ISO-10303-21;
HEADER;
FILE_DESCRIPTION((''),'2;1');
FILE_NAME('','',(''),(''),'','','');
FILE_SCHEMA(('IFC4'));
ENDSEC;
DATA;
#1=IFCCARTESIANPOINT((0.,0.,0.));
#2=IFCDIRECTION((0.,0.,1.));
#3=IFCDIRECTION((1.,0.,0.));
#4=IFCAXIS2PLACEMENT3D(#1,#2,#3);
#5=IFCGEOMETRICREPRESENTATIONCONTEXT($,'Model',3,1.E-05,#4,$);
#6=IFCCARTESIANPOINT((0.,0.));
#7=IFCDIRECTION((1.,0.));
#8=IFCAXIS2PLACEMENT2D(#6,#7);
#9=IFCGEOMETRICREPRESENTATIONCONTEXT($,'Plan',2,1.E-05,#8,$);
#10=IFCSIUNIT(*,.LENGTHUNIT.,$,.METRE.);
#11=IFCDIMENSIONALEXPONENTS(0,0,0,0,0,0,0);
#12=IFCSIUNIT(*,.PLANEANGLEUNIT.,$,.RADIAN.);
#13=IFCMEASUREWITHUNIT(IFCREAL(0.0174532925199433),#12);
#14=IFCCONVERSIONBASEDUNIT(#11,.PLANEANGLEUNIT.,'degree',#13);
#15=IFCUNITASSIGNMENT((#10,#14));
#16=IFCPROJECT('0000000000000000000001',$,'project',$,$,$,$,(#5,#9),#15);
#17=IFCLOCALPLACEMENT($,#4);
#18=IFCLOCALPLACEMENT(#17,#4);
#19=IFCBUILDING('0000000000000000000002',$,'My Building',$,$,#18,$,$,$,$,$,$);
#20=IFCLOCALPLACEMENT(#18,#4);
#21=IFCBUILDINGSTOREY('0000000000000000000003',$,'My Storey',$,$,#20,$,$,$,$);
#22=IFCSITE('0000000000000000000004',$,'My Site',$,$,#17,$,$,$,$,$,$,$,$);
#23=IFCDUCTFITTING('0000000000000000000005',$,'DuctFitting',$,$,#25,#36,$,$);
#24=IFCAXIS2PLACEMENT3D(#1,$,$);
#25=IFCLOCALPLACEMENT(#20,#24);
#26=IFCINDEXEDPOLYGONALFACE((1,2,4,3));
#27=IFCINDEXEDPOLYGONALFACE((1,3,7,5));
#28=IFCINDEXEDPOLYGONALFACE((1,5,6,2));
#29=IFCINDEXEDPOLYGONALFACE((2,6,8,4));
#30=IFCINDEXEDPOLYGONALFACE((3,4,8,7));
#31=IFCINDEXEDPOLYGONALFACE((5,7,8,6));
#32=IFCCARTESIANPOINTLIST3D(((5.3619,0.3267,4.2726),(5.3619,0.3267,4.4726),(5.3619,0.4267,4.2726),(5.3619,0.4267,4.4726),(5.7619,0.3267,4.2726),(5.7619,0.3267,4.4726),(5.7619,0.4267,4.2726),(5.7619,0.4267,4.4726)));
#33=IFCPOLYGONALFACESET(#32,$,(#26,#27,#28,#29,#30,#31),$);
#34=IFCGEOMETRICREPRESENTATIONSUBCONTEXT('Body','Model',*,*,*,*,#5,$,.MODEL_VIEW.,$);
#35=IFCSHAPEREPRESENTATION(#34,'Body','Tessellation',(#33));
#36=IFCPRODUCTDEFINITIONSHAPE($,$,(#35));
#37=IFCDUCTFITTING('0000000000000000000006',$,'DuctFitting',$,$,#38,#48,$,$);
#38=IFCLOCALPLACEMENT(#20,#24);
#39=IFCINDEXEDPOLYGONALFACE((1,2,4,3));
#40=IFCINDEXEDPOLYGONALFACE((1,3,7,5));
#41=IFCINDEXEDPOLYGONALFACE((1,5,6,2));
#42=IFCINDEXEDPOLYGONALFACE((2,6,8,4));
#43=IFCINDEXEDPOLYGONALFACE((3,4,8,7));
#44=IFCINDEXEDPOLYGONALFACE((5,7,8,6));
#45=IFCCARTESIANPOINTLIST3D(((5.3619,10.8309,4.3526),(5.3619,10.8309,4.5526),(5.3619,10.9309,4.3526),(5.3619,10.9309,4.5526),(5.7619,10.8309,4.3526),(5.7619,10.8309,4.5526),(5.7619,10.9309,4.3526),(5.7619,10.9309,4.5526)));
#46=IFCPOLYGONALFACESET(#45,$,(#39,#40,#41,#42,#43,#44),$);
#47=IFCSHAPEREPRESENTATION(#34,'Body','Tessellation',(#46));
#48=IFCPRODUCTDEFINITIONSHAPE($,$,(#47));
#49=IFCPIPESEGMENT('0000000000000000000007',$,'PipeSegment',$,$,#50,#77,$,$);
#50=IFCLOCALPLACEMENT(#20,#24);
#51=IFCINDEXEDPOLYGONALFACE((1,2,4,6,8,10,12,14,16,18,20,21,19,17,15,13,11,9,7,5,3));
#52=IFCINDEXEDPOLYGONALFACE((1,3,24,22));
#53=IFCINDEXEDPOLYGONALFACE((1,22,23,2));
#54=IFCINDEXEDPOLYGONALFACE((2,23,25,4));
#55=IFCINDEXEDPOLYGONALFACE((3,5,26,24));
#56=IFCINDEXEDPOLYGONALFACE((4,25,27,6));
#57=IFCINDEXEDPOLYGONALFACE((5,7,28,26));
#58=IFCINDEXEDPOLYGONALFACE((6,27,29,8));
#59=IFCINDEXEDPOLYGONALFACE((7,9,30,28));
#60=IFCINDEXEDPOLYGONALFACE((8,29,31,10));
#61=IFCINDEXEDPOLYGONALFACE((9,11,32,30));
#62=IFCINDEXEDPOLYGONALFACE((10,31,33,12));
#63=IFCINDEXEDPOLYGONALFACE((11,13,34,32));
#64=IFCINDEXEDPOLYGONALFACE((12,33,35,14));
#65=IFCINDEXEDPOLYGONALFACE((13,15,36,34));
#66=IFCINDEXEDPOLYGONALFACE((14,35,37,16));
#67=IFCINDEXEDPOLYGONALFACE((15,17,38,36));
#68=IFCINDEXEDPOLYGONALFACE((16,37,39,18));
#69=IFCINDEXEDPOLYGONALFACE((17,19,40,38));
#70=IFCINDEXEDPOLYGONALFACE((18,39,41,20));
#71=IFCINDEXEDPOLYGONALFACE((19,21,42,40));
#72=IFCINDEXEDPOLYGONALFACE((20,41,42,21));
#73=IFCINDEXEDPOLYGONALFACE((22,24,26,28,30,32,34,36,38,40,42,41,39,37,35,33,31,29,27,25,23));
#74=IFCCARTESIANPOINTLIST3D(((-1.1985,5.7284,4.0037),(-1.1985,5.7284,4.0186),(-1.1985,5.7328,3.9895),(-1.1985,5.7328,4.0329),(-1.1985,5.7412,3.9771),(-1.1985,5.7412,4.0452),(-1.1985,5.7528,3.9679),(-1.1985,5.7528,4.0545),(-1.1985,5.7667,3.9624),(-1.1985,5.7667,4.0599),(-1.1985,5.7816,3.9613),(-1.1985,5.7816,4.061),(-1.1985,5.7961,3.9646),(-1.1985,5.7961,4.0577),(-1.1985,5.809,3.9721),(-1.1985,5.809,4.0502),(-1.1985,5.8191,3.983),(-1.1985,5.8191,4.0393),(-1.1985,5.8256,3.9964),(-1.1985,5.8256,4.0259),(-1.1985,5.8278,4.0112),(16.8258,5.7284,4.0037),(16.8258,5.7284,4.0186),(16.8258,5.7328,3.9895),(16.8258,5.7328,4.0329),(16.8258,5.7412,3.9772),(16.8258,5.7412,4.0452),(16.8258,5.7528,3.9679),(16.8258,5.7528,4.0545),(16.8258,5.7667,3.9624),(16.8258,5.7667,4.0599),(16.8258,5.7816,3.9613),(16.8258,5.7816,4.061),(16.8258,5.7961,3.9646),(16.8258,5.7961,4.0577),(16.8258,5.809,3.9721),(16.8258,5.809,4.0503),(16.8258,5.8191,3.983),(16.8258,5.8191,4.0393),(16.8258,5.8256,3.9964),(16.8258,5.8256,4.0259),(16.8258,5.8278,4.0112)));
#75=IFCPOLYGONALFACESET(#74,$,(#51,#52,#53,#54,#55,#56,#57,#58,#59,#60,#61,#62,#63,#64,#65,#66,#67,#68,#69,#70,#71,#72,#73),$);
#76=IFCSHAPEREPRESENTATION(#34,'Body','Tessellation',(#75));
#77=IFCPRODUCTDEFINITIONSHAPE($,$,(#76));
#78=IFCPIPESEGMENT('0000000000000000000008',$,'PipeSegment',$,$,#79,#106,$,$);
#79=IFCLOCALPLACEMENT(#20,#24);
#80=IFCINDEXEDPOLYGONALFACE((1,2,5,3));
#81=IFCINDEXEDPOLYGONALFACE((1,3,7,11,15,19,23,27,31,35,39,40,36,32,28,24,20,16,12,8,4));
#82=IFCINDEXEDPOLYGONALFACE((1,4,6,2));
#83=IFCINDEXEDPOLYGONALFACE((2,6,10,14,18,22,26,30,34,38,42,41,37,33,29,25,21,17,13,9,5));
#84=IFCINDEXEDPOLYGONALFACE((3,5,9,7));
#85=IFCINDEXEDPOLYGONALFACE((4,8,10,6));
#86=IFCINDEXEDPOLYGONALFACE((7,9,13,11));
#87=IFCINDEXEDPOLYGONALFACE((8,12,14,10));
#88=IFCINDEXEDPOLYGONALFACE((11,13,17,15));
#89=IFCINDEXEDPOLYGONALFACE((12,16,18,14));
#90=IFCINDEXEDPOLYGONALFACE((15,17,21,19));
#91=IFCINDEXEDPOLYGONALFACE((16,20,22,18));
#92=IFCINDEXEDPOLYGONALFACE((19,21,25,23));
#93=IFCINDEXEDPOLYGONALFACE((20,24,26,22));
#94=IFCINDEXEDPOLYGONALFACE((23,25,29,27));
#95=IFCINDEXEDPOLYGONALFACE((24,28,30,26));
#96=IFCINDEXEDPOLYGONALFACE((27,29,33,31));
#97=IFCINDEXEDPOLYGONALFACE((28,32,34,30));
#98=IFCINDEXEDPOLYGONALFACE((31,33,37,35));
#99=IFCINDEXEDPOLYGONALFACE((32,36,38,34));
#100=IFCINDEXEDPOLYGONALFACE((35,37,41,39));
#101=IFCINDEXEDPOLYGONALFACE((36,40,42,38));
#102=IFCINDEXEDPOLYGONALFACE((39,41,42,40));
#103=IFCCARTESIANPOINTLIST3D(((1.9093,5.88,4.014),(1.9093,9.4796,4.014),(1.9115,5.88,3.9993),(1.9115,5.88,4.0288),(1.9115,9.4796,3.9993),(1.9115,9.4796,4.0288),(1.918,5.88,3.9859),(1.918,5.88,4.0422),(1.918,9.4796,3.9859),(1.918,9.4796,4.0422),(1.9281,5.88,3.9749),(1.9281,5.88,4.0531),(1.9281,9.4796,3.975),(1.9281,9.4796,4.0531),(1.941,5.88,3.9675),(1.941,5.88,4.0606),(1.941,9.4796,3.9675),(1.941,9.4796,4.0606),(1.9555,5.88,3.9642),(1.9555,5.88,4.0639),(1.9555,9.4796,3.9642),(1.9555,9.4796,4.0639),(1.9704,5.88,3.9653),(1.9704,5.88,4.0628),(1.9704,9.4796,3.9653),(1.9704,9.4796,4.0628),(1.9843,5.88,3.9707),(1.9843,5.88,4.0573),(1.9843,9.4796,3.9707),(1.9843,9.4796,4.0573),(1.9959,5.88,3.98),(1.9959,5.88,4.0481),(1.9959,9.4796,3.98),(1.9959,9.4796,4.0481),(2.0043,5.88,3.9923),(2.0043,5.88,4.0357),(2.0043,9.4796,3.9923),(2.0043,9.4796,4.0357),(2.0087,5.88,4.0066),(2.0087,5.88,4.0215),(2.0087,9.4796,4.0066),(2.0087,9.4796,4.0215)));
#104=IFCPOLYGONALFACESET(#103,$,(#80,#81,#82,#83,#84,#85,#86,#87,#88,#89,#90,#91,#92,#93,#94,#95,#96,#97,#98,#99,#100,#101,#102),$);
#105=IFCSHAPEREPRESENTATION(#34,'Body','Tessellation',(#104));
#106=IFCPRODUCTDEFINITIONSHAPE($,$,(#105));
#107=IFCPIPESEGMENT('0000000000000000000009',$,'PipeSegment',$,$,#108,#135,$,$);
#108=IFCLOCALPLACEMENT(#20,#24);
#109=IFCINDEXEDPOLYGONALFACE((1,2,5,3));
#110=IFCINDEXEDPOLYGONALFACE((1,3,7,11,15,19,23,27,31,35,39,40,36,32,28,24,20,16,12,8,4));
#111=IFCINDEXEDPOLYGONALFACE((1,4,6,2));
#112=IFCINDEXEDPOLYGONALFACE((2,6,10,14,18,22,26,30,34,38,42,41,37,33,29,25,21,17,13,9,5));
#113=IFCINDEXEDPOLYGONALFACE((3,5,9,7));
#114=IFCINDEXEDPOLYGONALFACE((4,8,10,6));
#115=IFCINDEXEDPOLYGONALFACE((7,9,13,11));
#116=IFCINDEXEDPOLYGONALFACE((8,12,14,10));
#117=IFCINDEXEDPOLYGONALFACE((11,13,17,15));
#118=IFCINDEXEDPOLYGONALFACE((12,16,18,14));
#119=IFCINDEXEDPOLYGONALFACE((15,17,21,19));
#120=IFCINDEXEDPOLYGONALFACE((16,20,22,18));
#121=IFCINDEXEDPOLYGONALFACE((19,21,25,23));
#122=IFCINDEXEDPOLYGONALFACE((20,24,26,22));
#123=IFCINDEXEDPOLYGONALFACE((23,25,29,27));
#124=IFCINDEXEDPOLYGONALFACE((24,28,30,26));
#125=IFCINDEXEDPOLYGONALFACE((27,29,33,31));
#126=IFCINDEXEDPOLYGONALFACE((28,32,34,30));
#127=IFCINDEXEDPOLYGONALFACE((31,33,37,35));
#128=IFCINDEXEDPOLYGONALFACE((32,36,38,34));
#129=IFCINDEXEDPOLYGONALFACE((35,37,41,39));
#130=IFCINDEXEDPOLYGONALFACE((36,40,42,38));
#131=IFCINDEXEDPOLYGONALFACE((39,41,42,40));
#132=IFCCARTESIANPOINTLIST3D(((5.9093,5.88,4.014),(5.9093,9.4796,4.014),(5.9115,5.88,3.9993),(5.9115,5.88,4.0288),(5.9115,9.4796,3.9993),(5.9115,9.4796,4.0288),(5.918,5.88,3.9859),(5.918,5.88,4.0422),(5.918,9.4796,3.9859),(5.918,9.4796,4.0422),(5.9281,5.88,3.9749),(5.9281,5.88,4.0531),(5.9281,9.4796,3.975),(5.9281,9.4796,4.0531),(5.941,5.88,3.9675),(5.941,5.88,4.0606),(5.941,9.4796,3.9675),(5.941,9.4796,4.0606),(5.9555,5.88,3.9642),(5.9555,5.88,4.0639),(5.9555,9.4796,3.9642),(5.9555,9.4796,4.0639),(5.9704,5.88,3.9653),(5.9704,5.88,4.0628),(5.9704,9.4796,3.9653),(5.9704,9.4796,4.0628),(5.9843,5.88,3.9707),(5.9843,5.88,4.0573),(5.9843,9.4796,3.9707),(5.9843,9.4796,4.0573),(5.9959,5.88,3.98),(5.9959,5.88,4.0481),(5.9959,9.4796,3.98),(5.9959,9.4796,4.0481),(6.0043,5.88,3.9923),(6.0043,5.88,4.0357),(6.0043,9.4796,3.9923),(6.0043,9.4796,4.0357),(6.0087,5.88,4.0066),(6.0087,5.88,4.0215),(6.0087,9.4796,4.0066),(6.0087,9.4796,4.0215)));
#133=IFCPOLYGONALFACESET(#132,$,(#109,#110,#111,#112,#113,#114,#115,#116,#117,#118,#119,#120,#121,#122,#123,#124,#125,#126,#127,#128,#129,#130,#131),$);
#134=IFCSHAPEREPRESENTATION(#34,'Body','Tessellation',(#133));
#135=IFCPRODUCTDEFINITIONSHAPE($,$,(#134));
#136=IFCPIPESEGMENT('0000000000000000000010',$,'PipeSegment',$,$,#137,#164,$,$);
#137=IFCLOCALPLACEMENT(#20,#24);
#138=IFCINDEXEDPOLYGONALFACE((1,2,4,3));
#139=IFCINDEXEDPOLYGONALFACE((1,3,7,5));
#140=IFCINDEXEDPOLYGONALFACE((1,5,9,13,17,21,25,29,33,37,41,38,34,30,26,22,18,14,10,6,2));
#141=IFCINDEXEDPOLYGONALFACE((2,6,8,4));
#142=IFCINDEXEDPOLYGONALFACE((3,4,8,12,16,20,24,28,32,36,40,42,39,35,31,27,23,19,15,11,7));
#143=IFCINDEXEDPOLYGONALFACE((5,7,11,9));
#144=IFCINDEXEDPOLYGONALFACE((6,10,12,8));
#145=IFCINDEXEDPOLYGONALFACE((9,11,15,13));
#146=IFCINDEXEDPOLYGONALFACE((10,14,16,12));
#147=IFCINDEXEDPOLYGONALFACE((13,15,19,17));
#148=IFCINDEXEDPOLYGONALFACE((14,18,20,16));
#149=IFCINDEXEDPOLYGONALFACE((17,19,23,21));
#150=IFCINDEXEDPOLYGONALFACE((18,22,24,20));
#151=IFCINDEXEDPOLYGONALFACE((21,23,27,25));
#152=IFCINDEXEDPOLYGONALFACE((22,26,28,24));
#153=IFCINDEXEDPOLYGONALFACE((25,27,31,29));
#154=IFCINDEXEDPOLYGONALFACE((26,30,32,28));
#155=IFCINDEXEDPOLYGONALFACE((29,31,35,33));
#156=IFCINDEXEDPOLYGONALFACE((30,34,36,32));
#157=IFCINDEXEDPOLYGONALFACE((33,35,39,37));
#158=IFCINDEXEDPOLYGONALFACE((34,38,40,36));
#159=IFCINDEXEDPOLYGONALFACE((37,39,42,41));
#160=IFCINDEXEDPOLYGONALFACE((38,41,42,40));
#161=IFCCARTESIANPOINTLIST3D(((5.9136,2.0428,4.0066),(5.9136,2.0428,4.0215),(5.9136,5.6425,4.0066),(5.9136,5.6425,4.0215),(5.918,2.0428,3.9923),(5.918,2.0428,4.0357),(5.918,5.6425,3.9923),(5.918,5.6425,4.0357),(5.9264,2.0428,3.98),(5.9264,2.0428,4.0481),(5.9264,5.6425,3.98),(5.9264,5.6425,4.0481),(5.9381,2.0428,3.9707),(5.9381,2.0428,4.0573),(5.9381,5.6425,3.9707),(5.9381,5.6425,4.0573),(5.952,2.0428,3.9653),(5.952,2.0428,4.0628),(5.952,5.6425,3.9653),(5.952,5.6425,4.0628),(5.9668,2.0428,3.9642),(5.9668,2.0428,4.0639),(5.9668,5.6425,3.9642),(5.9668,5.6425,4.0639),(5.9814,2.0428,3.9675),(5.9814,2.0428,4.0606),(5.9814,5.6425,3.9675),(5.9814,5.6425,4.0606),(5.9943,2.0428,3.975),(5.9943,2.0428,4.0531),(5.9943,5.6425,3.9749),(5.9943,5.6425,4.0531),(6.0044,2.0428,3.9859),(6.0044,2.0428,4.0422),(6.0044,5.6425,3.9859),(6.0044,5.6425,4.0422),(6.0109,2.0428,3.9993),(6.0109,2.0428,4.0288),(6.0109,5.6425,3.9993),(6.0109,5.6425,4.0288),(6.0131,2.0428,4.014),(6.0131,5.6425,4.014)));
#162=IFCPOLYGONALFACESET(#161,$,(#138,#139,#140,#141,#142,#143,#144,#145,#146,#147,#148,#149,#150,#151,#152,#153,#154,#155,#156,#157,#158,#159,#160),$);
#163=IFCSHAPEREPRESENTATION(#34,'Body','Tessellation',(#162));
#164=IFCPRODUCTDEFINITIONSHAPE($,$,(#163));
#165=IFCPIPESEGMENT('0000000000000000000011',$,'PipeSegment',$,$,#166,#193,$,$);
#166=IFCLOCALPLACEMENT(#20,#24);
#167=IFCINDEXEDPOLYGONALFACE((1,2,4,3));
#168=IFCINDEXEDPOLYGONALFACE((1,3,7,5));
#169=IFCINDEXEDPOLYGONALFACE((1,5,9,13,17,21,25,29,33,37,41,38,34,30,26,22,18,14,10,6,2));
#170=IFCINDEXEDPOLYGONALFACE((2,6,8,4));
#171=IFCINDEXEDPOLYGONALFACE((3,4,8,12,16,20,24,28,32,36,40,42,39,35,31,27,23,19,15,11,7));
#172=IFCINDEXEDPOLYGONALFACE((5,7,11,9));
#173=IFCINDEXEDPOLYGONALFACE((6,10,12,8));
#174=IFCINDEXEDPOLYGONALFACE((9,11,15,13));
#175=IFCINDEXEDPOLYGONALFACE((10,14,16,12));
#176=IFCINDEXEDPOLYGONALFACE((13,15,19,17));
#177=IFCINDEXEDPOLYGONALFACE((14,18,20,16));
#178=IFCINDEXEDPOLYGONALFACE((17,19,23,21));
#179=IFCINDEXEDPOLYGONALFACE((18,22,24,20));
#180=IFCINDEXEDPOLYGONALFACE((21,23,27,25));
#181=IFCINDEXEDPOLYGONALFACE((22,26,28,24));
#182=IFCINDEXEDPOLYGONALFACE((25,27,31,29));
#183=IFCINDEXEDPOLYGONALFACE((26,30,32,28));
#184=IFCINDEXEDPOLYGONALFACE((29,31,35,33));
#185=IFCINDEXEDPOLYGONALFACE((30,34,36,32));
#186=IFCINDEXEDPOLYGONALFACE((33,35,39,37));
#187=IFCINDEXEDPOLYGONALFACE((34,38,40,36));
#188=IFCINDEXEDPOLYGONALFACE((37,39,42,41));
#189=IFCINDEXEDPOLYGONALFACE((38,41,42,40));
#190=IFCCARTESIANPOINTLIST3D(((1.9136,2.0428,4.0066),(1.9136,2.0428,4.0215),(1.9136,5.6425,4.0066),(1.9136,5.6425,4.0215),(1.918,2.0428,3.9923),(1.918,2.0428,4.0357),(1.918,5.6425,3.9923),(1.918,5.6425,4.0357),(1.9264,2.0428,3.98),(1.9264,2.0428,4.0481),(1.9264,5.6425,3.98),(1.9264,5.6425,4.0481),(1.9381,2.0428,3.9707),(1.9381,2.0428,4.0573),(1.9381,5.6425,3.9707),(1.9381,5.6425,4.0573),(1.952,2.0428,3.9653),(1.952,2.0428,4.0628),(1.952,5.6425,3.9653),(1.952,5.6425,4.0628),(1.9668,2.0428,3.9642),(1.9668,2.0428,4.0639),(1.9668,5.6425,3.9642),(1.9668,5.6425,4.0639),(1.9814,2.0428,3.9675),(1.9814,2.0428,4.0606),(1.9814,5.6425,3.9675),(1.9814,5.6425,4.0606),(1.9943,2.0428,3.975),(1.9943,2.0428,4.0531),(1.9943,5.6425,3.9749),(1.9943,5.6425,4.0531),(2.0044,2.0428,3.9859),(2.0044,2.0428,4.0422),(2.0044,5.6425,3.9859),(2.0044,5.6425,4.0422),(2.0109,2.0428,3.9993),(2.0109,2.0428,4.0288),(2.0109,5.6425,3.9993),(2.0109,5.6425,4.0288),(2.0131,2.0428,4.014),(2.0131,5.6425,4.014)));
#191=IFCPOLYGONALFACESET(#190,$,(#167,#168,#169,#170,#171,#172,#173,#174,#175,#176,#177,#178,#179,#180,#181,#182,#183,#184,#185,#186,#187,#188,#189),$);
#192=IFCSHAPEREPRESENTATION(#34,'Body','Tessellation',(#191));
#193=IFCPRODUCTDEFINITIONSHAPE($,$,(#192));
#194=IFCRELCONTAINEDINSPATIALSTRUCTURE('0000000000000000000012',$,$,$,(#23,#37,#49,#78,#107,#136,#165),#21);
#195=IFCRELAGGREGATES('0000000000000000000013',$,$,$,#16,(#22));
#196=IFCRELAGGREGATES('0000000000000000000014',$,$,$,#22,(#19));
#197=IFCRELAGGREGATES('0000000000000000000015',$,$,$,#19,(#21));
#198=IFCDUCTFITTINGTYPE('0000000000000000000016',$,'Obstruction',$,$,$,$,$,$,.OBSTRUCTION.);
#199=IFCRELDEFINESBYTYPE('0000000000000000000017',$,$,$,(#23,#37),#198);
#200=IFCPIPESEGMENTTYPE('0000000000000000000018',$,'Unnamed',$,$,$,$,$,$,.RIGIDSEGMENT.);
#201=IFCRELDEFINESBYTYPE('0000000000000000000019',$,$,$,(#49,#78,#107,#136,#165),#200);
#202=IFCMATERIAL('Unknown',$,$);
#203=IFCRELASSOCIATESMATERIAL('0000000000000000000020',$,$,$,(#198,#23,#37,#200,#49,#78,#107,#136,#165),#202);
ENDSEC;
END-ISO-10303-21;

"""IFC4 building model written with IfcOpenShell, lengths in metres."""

from ifc_helpers import new_model, entity, si_unit, converted_unit, frame, origin_with_axes, origin_2d_with_axis, place, context, subcontext, project, spatial, rectangle, circle, extrude, material, material_profile, profile_set, profile_usage, type_object, element, save


model = new_model("IFC4")

# Units and contexts
model_context = context("Model", 3, precision=1e-05, world=origin_with_axes())
plan_context = context("Plan", 2, precision=1e-05, world=origin_2d_with_axis())
body_context = subcontext(model_context, "Body", "Model", "MODEL_VIEW")
ifc_project = project(units=[si_unit("LENGTHUNIT", "METRE"), converted_unit("PLANEANGLEUNIT", "degree", entity("IfcReal", 0.0174532925199433), si_unit("PLANEANGLEUNIT", "RADIAN"), dimensions=[0, 0, 0, 0, 0, 0, 0])], contexts=[model_context, plan_context])

# Site, building, storey
site_placement = place(None, origin_with_axes())
site = spatial("IfcSite", under=ifc_project, at=site_placement, Name="My Site")
building_placement = place(site_placement, origin_with_axes())
building = spatial("IfcBuilding", under=site, at=building_placement, Name="My Building")
storey_placement = place(building_placement, origin_with_axes())
storey = spatial("IfcBuildingStorey", under=building, at=storey_placement, Name="My Storey")

# Shared definitions
ifc_material = material(Name="Unknown")

# Duct fittings
ifc_material_profile_1 = material_profile(ifc_material, rectangle(XDim=0.4, YDim=0.2))
ifc_profile_set_1 = profile_set([ifc_material_profile_1])
ifc_profile_usage_1 = profile_usage(ifc_profile_set_1, cardinal=5)
duct_fitting_type_1 = type_object("IfcDuctFittingType", Name="Obstruction", PredefinedType="OBSTRUCTION", material=ifc_profile_set_1)
duct_fitting_1_placement = place(storey_placement, frame((5.5619, 0.3267, 4.3726), z_axis=(0.0, 1.0, 0.0), x_axis=(-1.0, 0.0, 0.0)))
element("IfcDuctFitting", 1, at=duct_fitting_1_placement, inside=storey, type_object=duct_fitting_type_1, material=ifc_profile_usage_1, Name="DuctFitting", context=body_context, shape_type="SweptSolid", body=[
    extrude(rectangle(XDim=0.4, YDim=0.2), origin_with_axes(), (0.0, 0.0, 1.0), 0.1),
])
ifc_profile_usage_2 = profile_usage(ifc_profile_set_1, cardinal=5)
duct_fitting_2_placement = place(storey_placement, frame((5.5619, 10.9309, 4.4526), z_axis=(0.0, -1.0, 0.0), x_axis=(1.0, 0.0, 0.0)))
element("IfcDuctFitting", 2, at=duct_fitting_2_placement, inside=storey, type_object=duct_fitting_type_1, material=ifc_profile_usage_2, Name="DuctFitting", context=body_context, shape_type="SweptSolid", body=[
    extrude(rectangle(XDim=0.4, YDim=0.2), origin_with_axes(), (0.0, 0.0, 1.0), 0.1),
])

# Pipe segments
ifc_material_profile_2 = material_profile(ifc_material, circle(Radius=0.05))
ifc_profile_set_2 = profile_set([ifc_material_profile_2])
ifc_profile_usage_3 = profile_usage(ifc_profile_set_2, cardinal=5)
pipe_segment_type = type_object("IfcPipeSegmentType", Name="Unnamed", PredefinedType="RIGIDSEGMENT", material=ifc_profile_set_2)
pipe_segment_1_placement = place(storey_placement, frame((-1.1985, 5.7778, 4.0112), z_axis=(1.0, 0.0, 0.0), x_axis=(0.0, 1.0, 0.0)))
element("IfcPipeSegment", 3, at=pipe_segment_1_placement, inside=storey, type_object=pipe_segment_type, material=ifc_profile_usage_3, Name="PipeSegment", context=body_context, shape_type="SweptSolid", body=[
    extrude(circle(Radius=0.05), origin_with_axes(), (0.0, 0.0, 1.0), 18.0244),
])
ifc_profile_usage_4 = profile_usage(ifc_profile_set_2, cardinal=5)
pipe_segment_2_placement = place(storey_placement, frame((1.9593, 5.88, 4.014), z_axis=(0.0, 1.0, 0.0), x_axis=(-1.0, 0.0, 0.0)))
element("IfcPipeSegment", 4, at=pipe_segment_2_placement, inside=storey, type_object=pipe_segment_type, material=ifc_profile_usage_4, Name="PipeSegment", context=body_context, shape_type="SweptSolid", body=[
    extrude(circle(Radius=0.05), origin_with_axes(), (0.0, 0.0, 1.0), 3.5996),
])
ifc_profile_usage_5 = profile_usage(ifc_profile_set_2, cardinal=5)
pipe_segment_3_placement = place(storey_placement, frame((5.9593, 5.88, 4.014), z_axis=(0.0, 1.0, 0.0), x_axis=(-1.0, 0.0, 0.0)))
element("IfcPipeSegment", 5, at=pipe_segment_3_placement, inside=storey, type_object=pipe_segment_type, material=ifc_profile_usage_5, Name="PipeSegment", context=body_context, shape_type="SweptSolid", body=[
    extrude(circle(Radius=0.05), origin_with_axes(), (0.0, 0.0, 1.0), 3.5996),
])
ifc_profile_usage_6 = profile_usage(ifc_profile_set_2, cardinal=5)
pipe_segment_4_placement = place(storey_placement, frame((5.9631, 5.6425, 4.014), z_axis=(0.0, -1.0, 0.0), x_axis=(1.0, 0.0, 0.0)))
element("IfcPipeSegment", 6, at=pipe_segment_4_placement, inside=storey, type_object=pipe_segment_type, material=ifc_profile_usage_6, Name="PipeSegment", context=body_context, shape_type="SweptSolid", body=[
    extrude(circle(Radius=0.05), origin_with_axes(), (0.0, 0.0, 1.0), 3.5996),
])
ifc_profile_usage_7 = profile_usage(ifc_profile_set_2, cardinal=5)
pipe_segment_5_placement = place(storey_placement, frame((1.9631, 5.6425, 4.014), z_axis=(0.0, -1.0, 0.0), x_axis=(1.0, 0.0, 0.0)))
element("IfcPipeSegment", 7, at=pipe_segment_5_placement, inside=storey, type_object=pipe_segment_type, material=ifc_profile_usage_7, Name="PipeSegment", context=body_context, shape_type="SweptSolid", body=[
    extrude(circle(Radius=0.05), origin_with_axes(), (0.0, 0.0, 1.0), 3.5996),
])

save(model, "model.ifc")
